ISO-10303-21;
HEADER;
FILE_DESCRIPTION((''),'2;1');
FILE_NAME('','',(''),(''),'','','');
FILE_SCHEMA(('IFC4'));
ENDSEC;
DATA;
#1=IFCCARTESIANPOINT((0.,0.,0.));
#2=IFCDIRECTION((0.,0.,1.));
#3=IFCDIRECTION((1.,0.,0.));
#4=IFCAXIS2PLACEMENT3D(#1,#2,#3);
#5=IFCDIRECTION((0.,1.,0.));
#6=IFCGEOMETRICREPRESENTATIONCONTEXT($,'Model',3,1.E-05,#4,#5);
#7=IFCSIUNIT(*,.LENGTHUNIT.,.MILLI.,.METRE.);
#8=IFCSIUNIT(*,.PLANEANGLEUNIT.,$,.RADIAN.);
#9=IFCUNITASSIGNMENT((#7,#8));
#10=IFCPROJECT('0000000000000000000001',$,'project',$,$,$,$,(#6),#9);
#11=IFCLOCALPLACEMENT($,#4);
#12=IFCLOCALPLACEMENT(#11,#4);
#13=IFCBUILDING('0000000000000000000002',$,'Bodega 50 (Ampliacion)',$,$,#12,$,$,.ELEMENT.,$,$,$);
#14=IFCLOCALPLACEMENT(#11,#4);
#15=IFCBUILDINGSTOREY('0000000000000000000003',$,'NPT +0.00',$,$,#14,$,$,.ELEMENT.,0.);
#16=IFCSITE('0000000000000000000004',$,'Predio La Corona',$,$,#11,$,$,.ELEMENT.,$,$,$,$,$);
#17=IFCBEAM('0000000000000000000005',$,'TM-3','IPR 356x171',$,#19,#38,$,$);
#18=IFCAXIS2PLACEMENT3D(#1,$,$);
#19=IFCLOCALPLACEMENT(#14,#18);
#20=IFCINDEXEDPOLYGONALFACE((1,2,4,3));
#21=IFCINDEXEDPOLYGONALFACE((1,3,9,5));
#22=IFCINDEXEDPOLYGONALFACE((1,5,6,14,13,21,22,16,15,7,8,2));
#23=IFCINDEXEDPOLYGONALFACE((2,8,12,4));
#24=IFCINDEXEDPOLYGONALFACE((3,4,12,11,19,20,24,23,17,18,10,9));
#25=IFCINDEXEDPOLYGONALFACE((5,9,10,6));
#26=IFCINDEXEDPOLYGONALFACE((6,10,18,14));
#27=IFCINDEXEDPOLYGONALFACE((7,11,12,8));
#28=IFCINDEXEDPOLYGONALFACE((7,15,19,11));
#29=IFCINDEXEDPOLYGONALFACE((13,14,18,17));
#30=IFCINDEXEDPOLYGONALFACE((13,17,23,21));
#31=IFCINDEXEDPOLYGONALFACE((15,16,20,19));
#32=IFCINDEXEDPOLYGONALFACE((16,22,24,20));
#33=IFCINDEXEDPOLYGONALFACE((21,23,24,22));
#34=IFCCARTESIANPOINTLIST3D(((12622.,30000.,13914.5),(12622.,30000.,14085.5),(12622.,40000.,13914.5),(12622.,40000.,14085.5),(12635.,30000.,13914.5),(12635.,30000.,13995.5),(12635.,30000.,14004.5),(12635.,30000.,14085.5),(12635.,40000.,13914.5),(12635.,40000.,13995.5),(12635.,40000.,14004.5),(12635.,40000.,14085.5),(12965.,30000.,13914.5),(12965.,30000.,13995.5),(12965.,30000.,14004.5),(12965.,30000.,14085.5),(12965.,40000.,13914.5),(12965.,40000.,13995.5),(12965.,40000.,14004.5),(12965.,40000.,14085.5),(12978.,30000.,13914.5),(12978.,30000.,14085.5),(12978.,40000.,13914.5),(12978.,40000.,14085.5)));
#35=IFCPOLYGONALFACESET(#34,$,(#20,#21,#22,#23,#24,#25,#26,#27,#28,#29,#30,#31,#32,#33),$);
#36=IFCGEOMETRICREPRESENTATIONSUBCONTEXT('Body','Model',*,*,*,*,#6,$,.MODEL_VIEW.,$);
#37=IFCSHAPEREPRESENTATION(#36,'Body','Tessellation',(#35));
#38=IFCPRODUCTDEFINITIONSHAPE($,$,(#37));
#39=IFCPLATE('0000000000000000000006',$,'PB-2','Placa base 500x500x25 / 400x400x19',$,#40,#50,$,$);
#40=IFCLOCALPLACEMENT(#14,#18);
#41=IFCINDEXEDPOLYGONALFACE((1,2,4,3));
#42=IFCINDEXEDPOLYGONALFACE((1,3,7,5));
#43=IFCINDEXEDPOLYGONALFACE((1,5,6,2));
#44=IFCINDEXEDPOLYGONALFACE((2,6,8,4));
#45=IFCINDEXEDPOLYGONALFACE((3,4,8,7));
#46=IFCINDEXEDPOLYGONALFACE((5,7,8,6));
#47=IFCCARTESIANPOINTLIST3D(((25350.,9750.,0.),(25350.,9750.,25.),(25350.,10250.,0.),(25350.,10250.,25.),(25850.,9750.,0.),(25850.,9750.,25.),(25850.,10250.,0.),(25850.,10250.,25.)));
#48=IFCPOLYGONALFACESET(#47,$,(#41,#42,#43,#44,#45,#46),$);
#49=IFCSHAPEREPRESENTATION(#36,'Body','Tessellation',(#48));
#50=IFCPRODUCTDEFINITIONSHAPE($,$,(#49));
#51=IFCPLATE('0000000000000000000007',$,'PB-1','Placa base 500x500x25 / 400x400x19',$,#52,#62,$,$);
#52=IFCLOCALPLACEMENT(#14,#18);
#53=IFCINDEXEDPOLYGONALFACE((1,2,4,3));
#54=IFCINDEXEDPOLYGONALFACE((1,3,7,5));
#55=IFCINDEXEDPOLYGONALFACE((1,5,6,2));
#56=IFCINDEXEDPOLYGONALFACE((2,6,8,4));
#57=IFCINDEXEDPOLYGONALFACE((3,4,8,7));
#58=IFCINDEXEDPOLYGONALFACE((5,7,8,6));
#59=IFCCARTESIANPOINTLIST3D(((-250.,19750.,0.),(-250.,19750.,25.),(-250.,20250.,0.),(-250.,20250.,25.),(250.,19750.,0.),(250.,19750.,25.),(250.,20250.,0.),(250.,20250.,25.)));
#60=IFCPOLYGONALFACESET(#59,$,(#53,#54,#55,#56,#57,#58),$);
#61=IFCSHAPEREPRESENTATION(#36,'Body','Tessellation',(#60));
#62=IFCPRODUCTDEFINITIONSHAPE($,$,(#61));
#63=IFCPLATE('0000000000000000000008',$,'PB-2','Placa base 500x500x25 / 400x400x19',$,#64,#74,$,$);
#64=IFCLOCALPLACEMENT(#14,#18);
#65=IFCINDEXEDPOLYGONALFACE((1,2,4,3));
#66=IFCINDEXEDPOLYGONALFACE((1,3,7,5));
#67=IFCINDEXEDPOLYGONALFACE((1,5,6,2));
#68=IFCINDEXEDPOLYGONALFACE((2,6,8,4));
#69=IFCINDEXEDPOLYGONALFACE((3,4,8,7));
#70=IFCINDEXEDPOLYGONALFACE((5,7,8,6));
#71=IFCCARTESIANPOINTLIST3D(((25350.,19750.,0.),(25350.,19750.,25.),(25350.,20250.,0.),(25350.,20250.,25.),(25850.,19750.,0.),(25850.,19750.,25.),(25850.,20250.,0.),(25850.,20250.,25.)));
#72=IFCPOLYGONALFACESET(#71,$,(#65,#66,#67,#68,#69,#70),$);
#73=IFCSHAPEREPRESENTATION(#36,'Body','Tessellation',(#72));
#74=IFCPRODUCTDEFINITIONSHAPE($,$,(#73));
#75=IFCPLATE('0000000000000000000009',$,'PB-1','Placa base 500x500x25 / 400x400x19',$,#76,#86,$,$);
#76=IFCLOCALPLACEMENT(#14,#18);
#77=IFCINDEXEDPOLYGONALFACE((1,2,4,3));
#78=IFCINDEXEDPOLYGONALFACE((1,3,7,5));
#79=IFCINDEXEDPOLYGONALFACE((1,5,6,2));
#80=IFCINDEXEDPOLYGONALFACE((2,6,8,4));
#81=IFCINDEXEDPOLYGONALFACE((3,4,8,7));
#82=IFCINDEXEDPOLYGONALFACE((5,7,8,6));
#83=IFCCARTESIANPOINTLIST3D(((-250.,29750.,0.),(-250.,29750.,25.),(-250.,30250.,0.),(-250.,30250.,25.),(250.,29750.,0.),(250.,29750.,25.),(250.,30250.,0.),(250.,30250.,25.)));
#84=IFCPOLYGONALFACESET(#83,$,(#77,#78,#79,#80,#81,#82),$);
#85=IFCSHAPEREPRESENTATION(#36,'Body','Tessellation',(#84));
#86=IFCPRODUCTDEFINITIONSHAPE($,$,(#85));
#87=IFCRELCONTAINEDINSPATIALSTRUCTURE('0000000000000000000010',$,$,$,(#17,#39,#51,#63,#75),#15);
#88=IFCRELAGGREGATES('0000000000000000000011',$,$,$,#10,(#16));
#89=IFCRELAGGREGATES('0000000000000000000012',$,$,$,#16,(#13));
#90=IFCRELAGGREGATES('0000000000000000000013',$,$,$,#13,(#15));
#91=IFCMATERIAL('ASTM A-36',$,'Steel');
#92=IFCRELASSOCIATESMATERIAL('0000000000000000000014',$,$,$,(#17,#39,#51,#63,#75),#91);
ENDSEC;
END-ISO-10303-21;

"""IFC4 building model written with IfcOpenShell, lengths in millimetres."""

from ifc_helpers import new_model, si_unit, direction, frame, origin_with_axes, origin_2d, place, context, subcontext, project, spatial, rectangle, i_section, extrude, material, element, save


model = new_model("IFC4")

# Units and contexts
model_context = context("Model", 3, precision=1e-05, world=origin_with_axes(), true_north=direction((0.0, 1.0, 0.0)))
body_context = subcontext(model_context, "Body", "Model", "MODEL_VIEW")
ifc_project = project(units=[si_unit("LENGTHUNIT", "METRE", prefix="MILLI"), si_unit("PLANEANGLEUNIT", "RADIAN")], contexts=[model_context])

# Site, building, storey
site_placement = place(None, origin_with_axes())
site = spatial("IfcSite", under=ifc_project, at=site_placement, Name="Predio La Corona", CompositionType="ELEMENT")
building_placement = place(site_placement, origin_with_axes())
building = spatial("IfcBuilding", under=site, at=building_placement, Name="Bodega 50 (Ampliacion)", CompositionType="ELEMENT")
storey_placement = place(site_placement, origin_with_axes())
storey = spatial("IfcBuildingStorey", under=building, at=storey_placement, Name="NPT +0.00", CompositionType="ELEMENT", Elevation=0.0)

# Shared definitions
ifc_material = material(Name="ASTM A-36", Category="Steel")

# Beam
for number, where, z_axis, x_axis, name in (
    (1, (12800.0, 30000.0, 14000.0), (0.0, 1.0, 0.0), (0.0, 0.0, 1.0), "TM-3"),
):
    element("IfcBeam", number, at=place(storey_placement, frame(where, z_axis=z_axis, x_axis=x_axis)), inside=storey, material=ifc_material, Name=name, Description="IPR 356x171", context=body_context, shape_type="SweptSolid", body=[
        extrude(i_section(OverallWidth=171.0, OverallDepth=356.0, WebThickness=9.0, FlangeThickness=13.0, at=origin_2d()), origin_with_axes(), (0.0, 0.0, 1.0), 10000.0),
    ])

# Plates
for number, where, z_axis, x_axis, name in (
    (2, (25600.0, 10000.0, 0.0), (0.0, 0.0, 1.0), (1.0, 0.0, 0.0), "PB-2"),
    (3, (0.0, 20000.0, 0.0), (0.0, 0.0, 1.0), (1.0, 0.0, 0.0), "PB-1"),
    (4, (25600.0, 20000.0, 0.0), (0.0, 0.0, 1.0), (1.0, 0.0, 0.0), "PB-2"),
    (5, (0.0, 30000.0, 0.0), (0.0, 0.0, 1.0), (1.0, 0.0, 0.0), "PB-1"),
):
    element("IfcPlate", number, at=place(storey_placement, frame(where, z_axis=z_axis, x_axis=x_axis)), inside=storey, material=ifc_material, Name=name, Description="Placa base 500x500x25 / 400x400x19", context=body_context, shape_type="SweptSolid", body=[
        extrude(rectangle(XDim=500.0, YDim=500.0, at=origin_2d()), origin_with_axes(), (0.0, 0.0, 1.0), 25.0),
    ])

save(model, "model.ifc")
